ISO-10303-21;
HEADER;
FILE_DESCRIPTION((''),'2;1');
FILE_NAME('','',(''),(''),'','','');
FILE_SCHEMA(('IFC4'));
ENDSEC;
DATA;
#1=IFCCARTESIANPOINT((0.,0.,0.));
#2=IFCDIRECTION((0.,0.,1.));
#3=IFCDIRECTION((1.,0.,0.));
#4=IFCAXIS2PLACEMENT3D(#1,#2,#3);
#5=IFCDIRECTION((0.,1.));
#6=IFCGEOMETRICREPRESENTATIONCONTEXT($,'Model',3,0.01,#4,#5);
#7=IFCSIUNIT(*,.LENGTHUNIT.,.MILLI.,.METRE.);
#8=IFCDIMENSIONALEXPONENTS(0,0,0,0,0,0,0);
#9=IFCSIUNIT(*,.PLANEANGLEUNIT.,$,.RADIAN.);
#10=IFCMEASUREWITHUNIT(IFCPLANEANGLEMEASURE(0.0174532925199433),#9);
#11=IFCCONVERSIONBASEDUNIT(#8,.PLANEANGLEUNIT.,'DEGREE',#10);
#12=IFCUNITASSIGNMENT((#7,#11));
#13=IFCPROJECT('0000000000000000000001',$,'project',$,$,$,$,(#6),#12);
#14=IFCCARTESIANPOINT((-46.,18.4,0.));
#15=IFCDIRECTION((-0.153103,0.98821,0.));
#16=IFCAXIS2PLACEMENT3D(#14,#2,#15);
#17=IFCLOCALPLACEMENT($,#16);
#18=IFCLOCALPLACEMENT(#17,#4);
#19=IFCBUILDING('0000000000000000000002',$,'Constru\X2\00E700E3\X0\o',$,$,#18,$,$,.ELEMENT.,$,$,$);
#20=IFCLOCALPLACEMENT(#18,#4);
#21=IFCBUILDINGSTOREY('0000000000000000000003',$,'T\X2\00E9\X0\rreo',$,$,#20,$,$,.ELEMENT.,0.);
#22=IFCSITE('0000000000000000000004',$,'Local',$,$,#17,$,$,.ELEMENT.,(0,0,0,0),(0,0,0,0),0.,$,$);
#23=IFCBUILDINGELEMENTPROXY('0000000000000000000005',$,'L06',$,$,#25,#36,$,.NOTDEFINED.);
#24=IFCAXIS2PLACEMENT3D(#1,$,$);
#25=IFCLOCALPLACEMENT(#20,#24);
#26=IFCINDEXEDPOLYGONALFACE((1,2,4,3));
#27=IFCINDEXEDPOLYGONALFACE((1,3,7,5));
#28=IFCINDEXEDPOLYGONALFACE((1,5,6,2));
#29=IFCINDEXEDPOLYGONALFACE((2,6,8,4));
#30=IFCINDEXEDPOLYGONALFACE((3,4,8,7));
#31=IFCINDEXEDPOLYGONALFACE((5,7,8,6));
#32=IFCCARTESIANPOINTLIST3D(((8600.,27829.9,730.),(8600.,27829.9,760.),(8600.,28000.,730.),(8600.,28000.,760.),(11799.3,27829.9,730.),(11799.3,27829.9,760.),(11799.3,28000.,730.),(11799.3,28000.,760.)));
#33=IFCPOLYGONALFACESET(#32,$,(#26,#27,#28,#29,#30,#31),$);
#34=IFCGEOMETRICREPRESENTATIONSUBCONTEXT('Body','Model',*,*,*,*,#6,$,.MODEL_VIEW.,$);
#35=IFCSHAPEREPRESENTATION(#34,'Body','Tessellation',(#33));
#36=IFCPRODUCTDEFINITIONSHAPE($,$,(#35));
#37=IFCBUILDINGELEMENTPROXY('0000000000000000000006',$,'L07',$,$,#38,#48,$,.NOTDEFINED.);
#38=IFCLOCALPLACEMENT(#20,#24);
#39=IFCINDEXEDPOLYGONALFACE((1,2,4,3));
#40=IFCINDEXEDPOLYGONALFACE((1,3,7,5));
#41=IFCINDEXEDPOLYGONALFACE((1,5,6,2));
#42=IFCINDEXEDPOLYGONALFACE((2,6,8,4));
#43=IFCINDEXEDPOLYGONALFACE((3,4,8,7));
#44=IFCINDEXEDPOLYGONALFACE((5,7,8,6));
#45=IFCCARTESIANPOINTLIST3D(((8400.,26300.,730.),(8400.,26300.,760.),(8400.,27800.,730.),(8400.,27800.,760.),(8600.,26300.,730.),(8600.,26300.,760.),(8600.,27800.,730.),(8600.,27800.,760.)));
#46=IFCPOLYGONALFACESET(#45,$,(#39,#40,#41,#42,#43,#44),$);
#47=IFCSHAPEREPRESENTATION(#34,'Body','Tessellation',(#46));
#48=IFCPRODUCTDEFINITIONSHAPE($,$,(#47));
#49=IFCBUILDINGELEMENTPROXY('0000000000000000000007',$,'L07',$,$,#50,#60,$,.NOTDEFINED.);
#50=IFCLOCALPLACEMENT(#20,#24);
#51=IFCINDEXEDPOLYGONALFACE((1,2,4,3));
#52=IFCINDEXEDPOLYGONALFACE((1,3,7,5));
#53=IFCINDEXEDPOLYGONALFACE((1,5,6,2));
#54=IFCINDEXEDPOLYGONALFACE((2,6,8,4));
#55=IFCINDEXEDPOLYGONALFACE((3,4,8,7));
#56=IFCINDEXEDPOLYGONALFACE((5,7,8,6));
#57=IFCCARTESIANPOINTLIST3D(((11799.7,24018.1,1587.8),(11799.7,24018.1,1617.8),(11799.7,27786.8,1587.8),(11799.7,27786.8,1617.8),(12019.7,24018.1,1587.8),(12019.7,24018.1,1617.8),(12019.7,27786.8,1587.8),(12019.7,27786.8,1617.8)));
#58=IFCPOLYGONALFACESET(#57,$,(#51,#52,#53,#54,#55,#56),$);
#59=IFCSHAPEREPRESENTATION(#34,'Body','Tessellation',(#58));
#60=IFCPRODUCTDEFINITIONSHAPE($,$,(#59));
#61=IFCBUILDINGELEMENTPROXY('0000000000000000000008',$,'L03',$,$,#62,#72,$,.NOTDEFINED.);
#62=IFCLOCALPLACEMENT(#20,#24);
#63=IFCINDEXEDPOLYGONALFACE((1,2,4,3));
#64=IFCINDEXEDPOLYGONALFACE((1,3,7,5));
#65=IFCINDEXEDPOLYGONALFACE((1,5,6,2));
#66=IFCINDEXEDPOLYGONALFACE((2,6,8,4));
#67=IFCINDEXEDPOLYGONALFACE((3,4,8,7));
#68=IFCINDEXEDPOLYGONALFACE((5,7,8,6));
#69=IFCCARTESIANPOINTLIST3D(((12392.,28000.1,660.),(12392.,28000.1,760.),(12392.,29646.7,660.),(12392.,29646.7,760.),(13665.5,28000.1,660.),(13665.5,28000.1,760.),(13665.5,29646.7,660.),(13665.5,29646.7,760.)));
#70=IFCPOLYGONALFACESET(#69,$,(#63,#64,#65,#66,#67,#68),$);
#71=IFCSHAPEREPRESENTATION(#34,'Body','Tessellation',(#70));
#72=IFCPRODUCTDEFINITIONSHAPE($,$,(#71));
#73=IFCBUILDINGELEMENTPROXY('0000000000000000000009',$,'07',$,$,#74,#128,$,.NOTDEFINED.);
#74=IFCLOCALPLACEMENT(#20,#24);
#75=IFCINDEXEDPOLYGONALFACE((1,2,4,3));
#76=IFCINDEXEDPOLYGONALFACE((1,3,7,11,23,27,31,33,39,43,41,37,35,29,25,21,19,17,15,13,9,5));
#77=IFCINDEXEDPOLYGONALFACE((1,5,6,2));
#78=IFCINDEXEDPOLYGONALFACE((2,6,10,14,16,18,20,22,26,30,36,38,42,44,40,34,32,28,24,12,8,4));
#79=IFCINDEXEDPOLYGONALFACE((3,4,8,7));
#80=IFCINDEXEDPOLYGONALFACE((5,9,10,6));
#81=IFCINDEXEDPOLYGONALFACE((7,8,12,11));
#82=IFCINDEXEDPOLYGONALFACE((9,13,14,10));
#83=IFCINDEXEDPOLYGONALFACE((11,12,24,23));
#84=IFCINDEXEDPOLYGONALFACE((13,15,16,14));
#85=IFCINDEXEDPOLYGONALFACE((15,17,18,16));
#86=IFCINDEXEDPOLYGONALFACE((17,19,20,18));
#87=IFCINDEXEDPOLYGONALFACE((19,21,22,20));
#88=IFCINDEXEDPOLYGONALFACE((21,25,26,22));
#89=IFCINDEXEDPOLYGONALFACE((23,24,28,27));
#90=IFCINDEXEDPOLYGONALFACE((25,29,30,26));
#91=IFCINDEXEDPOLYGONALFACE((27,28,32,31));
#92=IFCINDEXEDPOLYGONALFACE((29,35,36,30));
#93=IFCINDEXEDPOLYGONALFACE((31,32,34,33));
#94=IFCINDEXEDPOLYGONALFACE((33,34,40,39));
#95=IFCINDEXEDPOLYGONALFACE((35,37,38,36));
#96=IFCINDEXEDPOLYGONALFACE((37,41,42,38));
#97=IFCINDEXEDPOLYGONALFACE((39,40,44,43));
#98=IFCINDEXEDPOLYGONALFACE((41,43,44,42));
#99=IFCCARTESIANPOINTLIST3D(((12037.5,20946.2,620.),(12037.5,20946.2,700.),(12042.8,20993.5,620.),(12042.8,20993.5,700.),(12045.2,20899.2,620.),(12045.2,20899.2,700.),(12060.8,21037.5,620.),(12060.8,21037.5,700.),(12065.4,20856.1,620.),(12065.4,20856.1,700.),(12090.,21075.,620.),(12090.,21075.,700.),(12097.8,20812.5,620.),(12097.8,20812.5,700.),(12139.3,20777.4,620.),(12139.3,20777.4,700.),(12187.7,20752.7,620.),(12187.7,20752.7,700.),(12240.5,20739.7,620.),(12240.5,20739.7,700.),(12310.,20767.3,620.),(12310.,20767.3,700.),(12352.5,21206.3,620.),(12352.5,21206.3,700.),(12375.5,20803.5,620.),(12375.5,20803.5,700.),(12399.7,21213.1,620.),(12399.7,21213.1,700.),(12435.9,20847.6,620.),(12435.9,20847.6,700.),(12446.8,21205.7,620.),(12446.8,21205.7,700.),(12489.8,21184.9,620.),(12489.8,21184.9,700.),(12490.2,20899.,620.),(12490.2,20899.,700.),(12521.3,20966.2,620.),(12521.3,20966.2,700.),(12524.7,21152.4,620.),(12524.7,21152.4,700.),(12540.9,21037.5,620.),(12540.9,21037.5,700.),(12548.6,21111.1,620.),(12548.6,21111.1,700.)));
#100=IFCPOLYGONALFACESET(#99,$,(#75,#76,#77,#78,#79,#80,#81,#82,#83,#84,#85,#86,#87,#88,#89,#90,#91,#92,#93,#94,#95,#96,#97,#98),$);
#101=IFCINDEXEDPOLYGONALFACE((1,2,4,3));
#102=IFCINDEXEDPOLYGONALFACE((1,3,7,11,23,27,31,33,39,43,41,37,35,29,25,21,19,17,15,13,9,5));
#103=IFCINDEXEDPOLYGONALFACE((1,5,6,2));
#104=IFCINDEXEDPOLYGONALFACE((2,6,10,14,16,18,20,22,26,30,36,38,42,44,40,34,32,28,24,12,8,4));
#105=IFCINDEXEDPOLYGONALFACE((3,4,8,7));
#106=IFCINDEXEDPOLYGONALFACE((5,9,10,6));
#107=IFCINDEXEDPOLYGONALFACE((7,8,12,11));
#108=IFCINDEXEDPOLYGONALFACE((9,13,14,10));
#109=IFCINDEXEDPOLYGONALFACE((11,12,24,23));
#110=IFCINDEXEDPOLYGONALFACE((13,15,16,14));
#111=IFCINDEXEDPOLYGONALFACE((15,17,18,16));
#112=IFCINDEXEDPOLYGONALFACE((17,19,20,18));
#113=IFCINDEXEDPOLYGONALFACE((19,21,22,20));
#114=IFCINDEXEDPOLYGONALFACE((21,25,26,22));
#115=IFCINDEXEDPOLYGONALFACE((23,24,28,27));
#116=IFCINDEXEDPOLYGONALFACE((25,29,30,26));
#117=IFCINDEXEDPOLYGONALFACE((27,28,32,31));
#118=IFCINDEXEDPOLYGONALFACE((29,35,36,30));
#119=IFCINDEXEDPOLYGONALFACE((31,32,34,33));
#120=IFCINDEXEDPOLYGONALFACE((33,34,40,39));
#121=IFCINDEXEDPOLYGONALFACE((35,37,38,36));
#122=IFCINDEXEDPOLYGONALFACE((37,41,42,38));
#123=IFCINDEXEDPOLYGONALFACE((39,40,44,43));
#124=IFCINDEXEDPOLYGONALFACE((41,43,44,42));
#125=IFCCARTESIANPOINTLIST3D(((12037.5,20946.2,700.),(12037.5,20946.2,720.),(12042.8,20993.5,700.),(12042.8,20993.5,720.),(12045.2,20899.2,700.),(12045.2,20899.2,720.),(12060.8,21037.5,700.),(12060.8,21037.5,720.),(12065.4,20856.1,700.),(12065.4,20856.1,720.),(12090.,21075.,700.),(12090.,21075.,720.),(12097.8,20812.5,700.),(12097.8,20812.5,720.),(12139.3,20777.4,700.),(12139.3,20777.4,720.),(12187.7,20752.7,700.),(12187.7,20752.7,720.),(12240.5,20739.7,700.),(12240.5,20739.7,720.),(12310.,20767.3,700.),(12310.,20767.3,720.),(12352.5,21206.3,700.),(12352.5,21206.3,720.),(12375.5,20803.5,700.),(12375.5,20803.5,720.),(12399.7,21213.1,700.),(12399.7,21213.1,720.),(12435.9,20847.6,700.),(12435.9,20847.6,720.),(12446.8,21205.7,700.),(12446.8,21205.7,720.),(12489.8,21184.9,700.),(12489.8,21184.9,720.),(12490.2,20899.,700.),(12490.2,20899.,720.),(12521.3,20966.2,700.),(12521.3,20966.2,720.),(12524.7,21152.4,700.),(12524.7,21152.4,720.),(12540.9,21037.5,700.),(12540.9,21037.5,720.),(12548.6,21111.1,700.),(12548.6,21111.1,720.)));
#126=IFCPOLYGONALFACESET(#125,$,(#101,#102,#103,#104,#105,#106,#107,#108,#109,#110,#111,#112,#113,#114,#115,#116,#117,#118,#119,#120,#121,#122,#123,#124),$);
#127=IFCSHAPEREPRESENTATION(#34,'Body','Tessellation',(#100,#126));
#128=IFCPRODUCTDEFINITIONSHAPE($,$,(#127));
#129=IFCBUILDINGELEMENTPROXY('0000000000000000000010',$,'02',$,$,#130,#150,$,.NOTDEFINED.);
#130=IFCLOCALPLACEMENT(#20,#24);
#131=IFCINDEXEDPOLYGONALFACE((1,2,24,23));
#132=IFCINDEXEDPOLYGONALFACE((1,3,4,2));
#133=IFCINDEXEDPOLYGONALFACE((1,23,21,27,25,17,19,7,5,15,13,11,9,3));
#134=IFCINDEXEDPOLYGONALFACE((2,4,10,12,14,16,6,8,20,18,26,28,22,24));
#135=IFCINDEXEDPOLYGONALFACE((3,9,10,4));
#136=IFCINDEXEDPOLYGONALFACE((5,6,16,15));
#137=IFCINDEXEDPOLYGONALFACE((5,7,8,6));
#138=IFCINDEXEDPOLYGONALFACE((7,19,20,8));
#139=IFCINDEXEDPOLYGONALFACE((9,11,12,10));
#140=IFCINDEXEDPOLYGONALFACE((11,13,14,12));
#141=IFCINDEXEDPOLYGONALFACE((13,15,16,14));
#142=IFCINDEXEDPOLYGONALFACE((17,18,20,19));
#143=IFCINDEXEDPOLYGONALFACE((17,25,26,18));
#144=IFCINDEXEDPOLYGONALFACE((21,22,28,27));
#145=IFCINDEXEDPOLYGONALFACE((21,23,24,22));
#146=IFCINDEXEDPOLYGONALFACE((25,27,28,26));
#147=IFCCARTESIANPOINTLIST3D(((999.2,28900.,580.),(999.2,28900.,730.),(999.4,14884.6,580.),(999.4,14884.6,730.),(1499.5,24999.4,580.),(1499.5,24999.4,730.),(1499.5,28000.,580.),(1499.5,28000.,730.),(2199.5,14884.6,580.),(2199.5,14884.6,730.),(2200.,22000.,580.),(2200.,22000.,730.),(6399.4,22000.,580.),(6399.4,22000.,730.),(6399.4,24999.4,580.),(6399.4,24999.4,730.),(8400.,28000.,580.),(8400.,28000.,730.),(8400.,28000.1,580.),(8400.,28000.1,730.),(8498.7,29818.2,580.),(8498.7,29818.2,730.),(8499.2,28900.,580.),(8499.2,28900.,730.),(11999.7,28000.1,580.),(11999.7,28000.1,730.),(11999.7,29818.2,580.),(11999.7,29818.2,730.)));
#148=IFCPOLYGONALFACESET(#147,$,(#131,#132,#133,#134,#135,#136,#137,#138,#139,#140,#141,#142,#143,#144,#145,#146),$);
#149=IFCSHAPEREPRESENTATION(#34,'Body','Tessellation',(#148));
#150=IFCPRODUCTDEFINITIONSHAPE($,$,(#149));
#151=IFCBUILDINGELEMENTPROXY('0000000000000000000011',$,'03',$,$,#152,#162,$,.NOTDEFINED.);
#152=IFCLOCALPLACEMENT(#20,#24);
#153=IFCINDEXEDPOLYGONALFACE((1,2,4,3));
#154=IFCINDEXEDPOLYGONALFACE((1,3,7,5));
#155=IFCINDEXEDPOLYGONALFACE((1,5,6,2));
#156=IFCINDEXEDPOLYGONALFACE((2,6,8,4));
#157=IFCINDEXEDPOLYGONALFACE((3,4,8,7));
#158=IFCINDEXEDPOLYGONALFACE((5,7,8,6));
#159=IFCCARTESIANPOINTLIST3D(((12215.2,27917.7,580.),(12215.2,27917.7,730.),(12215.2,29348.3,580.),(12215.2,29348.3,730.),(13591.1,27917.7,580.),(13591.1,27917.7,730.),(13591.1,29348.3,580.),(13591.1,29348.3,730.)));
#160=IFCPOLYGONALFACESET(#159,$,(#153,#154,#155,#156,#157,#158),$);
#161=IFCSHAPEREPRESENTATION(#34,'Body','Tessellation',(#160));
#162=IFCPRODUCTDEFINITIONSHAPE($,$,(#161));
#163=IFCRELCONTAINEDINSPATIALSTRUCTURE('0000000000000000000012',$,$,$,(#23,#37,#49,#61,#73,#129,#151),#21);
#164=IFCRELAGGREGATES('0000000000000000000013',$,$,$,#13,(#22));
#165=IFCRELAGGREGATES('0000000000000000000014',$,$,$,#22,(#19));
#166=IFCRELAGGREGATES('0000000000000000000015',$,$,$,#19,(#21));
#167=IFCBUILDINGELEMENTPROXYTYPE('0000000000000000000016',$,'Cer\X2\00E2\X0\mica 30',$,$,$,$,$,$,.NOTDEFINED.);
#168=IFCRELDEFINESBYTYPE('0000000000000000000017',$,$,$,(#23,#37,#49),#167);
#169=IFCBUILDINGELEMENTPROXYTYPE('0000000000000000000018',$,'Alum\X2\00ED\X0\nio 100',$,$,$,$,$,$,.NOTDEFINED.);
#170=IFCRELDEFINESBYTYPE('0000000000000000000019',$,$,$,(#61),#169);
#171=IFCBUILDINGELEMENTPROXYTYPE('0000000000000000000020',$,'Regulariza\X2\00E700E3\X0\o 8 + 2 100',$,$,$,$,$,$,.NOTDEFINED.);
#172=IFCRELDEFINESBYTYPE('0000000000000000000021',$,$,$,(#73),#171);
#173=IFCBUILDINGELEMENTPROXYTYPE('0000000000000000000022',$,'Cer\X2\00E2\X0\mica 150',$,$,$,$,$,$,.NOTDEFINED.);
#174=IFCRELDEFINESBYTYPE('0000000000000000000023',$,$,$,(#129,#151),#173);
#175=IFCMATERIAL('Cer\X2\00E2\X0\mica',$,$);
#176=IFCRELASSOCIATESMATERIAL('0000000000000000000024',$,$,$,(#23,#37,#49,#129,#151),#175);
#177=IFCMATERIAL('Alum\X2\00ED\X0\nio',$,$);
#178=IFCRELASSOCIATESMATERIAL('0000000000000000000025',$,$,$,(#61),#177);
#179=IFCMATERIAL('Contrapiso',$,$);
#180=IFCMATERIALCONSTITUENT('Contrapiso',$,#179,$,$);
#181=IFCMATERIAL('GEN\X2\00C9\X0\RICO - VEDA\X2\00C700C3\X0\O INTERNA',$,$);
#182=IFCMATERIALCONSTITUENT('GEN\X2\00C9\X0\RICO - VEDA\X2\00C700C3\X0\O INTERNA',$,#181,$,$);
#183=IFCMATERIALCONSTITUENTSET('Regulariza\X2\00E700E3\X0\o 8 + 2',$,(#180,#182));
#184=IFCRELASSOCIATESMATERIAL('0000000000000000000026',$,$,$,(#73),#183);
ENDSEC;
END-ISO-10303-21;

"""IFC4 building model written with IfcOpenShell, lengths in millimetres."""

from ifc_helpers import new_model, entity, si_unit, converted_unit, direction, frame, origin_with_axes, place, context, subcontext, project, spatial, line, arc, indexed_curve, outline, extrude, material, constituent, constituent_set, type_object, element, save


model = new_model("IFC4")

# Units and contexts
model_context = context("Model", 3, precision=0.01, world=origin_with_axes(), true_north=direction((0.0, 1.0)))
body_context = subcontext(model_context, "Body", "Model", "MODEL_VIEW")
ifc_project = project(units=[si_unit("LENGTHUNIT", "METRE", prefix="MILLI"), converted_unit("PLANEANGLEUNIT", "DEGREE", entity("IfcPlaneAngleMeasure", 0.0174532925199433), si_unit("PLANEANGLEUNIT", "RADIAN"), dimensions=[0, 0, 0, 0, 0, 0, 0])], contexts=[model_context])

# Site, building, storey
site_placement = place(None, frame((-46.0, 18.4, 0.0), z_axis=(0.0, 0.0, 1.0), x_axis=(-0.153103, 0.98821, 0.0)))
site = spatial("IfcSite", under=ifc_project, at=site_placement, Name="Local", CompositionType="ELEMENT", RefLatitude=(0, 0, 0, 0), RefLongitude=(0, 0, 0, 0), RefElevation=0.0)
building_placement = place(site_placement, origin_with_axes())
building = spatial("IfcBuilding", under=site, at=building_placement, Name="Construção", CompositionType="ELEMENT")
storey_placement = place(building_placement, origin_with_axes())
storey = spatial("IfcBuildingStorey", under=building, at=storey_placement, Name="Térreo", CompositionType="ELEMENT", Elevation=0.0)

# Shared definitions
ifc_material_1 = material(Name="GENÉRICO - VEDAÇÃO INTERNA")

# Building element proxies
ifc_material_2 = material(Name="Cerâmica")
building_element_proxy_type_1 = type_object("IfcBuildingElementProxyType", Name="Cerâmica 30", PredefinedType="NOTDEFINED")
proxy_1_placement = place(storey_placement, frame((8600.0, 27829.9, 760.0), z_axis=(0.0, 0.0, 1.0), x_axis=(1.0, 0.0, 0.0)))
element("IfcBuildingElementProxy", 1, at=proxy_1_placement, inside=storey, type_object=building_element_proxy_type_1, material=ifc_material_2, Name="L06", PredefinedType="NOTDEFINED", context=body_context, shape_type="SweptSolid", body=[
    extrude(outline(indexed_curve([(0.0, 0.0), (3199.4, 0.0), (3199.4, 170.1), (0.0, 170.1)], segments=[line(1, 2, 3, 4, 1)])), frame((0.0, 0.0, -30.0), z_axis=(0.0, 0.0, 1.0), x_axis=(1.0, 0.0, 0.0)), (0.0, 0.0, 1.0), 30.0),
])
proxy_2_placement = place(storey_placement, frame((8600.0, 27800.0, 760.0), z_axis=(0.0, 0.0, 1.0), x_axis=(1.0, 0.0, 0.0)))
element("IfcBuildingElementProxy", 2, at=proxy_2_placement, inside=storey, type_object=building_element_proxy_type_1, material=ifc_material_2, Name="L07", PredefinedType="NOTDEFINED", context=body_context, shape_type="SweptSolid", body=[
    extrude(outline(indexed_curve([(0.0, 0.0), (-200.0, 0.0), (-200.0, -1500.0), (0.0, -1500.0)], segments=[line(1, 2, 3, 4, 1)])), frame((0.0, 0.0, -30.0), z_axis=(0.0, 0.0, 1.0), x_axis=(1.0, 0.0, 0.0)), (0.0, 0.0, 1.0), 30.0),
])
proxy_3_placement = place(storey_placement, frame((11799.7, 24018.1, 1617.8), z_axis=(0.0, 0.0, 1.0), x_axis=(1.0, 0.0, 0.0)))
element("IfcBuildingElementProxy", 3, at=proxy_3_placement, inside=storey, type_object=building_element_proxy_type_1, material=ifc_material_2, Name="L07", PredefinedType="NOTDEFINED", context=body_context, shape_type="SweptSolid", body=[
    extrude(outline(indexed_curve([(0.0, 0.0), (220.0, 0.0), (219.9, 3768.7), (-0.1, 3768.7)], segments=[line(1, 2, 3, 4, 1)])), frame((0.0, 0.0, -30.0), z_axis=(0.0, 0.0, 1.0), x_axis=(1.0, 0.0, 0.0)), (0.0, 0.0, 1.0), 30.0),
])
ifc_material_3 = material(Name="Alumínio")
building_element_proxy_type_2 = type_object("IfcBuildingElementProxyType", Name="Alumínio 100", PredefinedType="NOTDEFINED")
proxy_4_placement = place(storey_placement, frame((12392.0, 29646.7, 760.0), z_axis=(0.0, 0.0, 1.0), x_axis=(1.0, 0.0, 0.0)))
element("IfcBuildingElementProxy", 4, at=proxy_4_placement, inside=storey, type_object=building_element_proxy_type_2, material=ifc_material_3, Name="L03", PredefinedType="NOTDEFINED", context=body_context, shape_type="SweptSolid", body=[
    extrude(outline(indexed_curve([(0.0, 0.0), (0.0, -1646.7), (1273.5, -1646.7), (1273.5, 0.0)], segments=[line(1, 2, 3, 4, 1)])), frame((0.0, 0.0, -100.0), z_axis=(0.0, 0.0, 1.0), x_axis=(1.0, 0.0, 0.0)), (0.0, 0.0, 1.0), 100.0),
])
ifc_material_4 = material(Name="Contrapiso")
ifc_constituent_1 = constituent(ifc_material_4, Name="Contrapiso")
ifc_constituent_2 = constituent(ifc_material_1, Name="GENÉRICO - VEDAÇÃO INTERNA")
ifc_constituent_set = constituent_set(constituents=[ifc_constituent_1, ifc_constituent_2], Name="Regularização 8 + 2")
building_element_proxy_type_3 = type_object("IfcBuildingElementProxyType", Name="Regularização 8 + 2 100", PredefinedType="NOTDEFINED")
proxy_5_placement = place(storey_placement, frame((12090.0, 21075.0, 720.0), z_axis=(0.0, 0.0, 1.0), x_axis=(1.0, 0.0, 0.0)))
element("IfcBuildingElementProxy", 5, at=proxy_5_placement, inside=storey, type_object=building_element_proxy_type_3, material=ifc_constituent_set, Name="07", PredefinedType="NOTDEFINED", context=body_context, shape_type="SweptSolid", body=[
    extrude(outline(indexed_curve([(0.0, 0.0), (-51.5, -105.0), (-24.6, -218.9), (49.3, -297.7), (150.5, -335.3), (285.5, -271.6), (400.2, -176.0), (442.6, -73.6), (458.6, 36.0), (379.1, 121.8), (262.5, 131.3)], segments=[arc(1, 2, 3), arc(3, 4, 5), arc(5, 6, 7), arc(7, 8, 9), arc(9, 10, 11), line(11, 1)])), frame((0.0, 0.0, -100.0), z_axis=(0.0, 0.0, 1.0), x_axis=(1.0, 0.0, 0.0)), (0.0, 0.0, 1.0), 80.0),
    extrude(outline(indexed_curve([(0.0, 0.0), (-51.5, -105.0), (-24.6, -218.9), (49.3, -297.7), (150.5, -335.3), (285.5, -271.6), (400.2, -176.0), (442.6, -73.6), (458.6, 36.0), (379.1, 121.8), (262.5, 131.3)], segments=[arc(1, 2, 3), arc(3, 4, 5), arc(5, 6, 7), arc(7, 8, 9), arc(9, 10, 11), line(11, 1)])), frame((0.0, 0.0, -20.0), z_axis=(0.0, 0.0, 1.0), x_axis=(1.0, 0.0, 0.0)), (0.0, 0.0, 1.0), 20.0),
])
building_element_proxy_type_4 = type_object("IfcBuildingElementProxyType", Name="Cerâmica 150", PredefinedType="NOTDEFINED")
proxy_6_placement = place(storey_placement, frame((8499.2, 28900.0, 730.0), z_axis=(0.0, 0.0, 1.0), x_axis=(1.0, 0.0, 0.0)))
element("IfcBuildingElementProxy", 6, at=proxy_6_placement, inside=storey, type_object=building_element_proxy_type_4, material=ifc_material_2, Name="02", PredefinedType="NOTDEFINED", context=body_context, shape_type="SweptSolid", body=[
    extrude(outline(indexed_curve([(0.0, 0.0), (-7500.1, 0.0), (-7499.9, -14015.4), (-6299.8, -14015.4), (-6299.2, -6900.0), (-2099.8, -6900.0), (-2099.9, -3900.6), (-6999.8, -3900.6), (-6999.8, -900.0), (-99.3, -900.0), (-99.3, -900.0), (3500.4, -899.9), (3500.4, 918.2), (-0.5, 918.2)], segments=[line(1, 2, 3, 4, 5, 6, 7, 8, 9, 10, 11, 12, 13, 14, 1)])), frame((0.0, 0.0, -150.0), z_axis=(0.0, 0.0, 1.0), x_axis=(1.0, 0.0, 0.0)), (0.0, 0.0, 1.0), 150.0),
])
proxy_7_placement = place(storey_placement, frame((12215.2, 27917.7, 730.0), z_axis=(0.0, 0.0, 1.0), x_axis=(1.0, 0.0, 0.0)))
element("IfcBuildingElementProxy", 7, at=proxy_7_placement, inside=storey, type_object=building_element_proxy_type_4, material=ifc_material_2, Name="03", PredefinedType="NOTDEFINED", context=body_context, shape_type="SweptSolid", body=[
    extrude(outline(indexed_curve([(0.0, 0.0), (1375.9, 0.0), (1375.9, 1430.6), (0.0, 1430.6)], segments=[line(1, 2, 3, 4, 1)])), frame((0.0, 0.0, -150.0), z_axis=(0.0, 0.0, 1.0), x_axis=(1.0, 0.0, 0.0)), (0.0, 0.0, 1.0), 150.0),
])

save(model, "model.ifc")
